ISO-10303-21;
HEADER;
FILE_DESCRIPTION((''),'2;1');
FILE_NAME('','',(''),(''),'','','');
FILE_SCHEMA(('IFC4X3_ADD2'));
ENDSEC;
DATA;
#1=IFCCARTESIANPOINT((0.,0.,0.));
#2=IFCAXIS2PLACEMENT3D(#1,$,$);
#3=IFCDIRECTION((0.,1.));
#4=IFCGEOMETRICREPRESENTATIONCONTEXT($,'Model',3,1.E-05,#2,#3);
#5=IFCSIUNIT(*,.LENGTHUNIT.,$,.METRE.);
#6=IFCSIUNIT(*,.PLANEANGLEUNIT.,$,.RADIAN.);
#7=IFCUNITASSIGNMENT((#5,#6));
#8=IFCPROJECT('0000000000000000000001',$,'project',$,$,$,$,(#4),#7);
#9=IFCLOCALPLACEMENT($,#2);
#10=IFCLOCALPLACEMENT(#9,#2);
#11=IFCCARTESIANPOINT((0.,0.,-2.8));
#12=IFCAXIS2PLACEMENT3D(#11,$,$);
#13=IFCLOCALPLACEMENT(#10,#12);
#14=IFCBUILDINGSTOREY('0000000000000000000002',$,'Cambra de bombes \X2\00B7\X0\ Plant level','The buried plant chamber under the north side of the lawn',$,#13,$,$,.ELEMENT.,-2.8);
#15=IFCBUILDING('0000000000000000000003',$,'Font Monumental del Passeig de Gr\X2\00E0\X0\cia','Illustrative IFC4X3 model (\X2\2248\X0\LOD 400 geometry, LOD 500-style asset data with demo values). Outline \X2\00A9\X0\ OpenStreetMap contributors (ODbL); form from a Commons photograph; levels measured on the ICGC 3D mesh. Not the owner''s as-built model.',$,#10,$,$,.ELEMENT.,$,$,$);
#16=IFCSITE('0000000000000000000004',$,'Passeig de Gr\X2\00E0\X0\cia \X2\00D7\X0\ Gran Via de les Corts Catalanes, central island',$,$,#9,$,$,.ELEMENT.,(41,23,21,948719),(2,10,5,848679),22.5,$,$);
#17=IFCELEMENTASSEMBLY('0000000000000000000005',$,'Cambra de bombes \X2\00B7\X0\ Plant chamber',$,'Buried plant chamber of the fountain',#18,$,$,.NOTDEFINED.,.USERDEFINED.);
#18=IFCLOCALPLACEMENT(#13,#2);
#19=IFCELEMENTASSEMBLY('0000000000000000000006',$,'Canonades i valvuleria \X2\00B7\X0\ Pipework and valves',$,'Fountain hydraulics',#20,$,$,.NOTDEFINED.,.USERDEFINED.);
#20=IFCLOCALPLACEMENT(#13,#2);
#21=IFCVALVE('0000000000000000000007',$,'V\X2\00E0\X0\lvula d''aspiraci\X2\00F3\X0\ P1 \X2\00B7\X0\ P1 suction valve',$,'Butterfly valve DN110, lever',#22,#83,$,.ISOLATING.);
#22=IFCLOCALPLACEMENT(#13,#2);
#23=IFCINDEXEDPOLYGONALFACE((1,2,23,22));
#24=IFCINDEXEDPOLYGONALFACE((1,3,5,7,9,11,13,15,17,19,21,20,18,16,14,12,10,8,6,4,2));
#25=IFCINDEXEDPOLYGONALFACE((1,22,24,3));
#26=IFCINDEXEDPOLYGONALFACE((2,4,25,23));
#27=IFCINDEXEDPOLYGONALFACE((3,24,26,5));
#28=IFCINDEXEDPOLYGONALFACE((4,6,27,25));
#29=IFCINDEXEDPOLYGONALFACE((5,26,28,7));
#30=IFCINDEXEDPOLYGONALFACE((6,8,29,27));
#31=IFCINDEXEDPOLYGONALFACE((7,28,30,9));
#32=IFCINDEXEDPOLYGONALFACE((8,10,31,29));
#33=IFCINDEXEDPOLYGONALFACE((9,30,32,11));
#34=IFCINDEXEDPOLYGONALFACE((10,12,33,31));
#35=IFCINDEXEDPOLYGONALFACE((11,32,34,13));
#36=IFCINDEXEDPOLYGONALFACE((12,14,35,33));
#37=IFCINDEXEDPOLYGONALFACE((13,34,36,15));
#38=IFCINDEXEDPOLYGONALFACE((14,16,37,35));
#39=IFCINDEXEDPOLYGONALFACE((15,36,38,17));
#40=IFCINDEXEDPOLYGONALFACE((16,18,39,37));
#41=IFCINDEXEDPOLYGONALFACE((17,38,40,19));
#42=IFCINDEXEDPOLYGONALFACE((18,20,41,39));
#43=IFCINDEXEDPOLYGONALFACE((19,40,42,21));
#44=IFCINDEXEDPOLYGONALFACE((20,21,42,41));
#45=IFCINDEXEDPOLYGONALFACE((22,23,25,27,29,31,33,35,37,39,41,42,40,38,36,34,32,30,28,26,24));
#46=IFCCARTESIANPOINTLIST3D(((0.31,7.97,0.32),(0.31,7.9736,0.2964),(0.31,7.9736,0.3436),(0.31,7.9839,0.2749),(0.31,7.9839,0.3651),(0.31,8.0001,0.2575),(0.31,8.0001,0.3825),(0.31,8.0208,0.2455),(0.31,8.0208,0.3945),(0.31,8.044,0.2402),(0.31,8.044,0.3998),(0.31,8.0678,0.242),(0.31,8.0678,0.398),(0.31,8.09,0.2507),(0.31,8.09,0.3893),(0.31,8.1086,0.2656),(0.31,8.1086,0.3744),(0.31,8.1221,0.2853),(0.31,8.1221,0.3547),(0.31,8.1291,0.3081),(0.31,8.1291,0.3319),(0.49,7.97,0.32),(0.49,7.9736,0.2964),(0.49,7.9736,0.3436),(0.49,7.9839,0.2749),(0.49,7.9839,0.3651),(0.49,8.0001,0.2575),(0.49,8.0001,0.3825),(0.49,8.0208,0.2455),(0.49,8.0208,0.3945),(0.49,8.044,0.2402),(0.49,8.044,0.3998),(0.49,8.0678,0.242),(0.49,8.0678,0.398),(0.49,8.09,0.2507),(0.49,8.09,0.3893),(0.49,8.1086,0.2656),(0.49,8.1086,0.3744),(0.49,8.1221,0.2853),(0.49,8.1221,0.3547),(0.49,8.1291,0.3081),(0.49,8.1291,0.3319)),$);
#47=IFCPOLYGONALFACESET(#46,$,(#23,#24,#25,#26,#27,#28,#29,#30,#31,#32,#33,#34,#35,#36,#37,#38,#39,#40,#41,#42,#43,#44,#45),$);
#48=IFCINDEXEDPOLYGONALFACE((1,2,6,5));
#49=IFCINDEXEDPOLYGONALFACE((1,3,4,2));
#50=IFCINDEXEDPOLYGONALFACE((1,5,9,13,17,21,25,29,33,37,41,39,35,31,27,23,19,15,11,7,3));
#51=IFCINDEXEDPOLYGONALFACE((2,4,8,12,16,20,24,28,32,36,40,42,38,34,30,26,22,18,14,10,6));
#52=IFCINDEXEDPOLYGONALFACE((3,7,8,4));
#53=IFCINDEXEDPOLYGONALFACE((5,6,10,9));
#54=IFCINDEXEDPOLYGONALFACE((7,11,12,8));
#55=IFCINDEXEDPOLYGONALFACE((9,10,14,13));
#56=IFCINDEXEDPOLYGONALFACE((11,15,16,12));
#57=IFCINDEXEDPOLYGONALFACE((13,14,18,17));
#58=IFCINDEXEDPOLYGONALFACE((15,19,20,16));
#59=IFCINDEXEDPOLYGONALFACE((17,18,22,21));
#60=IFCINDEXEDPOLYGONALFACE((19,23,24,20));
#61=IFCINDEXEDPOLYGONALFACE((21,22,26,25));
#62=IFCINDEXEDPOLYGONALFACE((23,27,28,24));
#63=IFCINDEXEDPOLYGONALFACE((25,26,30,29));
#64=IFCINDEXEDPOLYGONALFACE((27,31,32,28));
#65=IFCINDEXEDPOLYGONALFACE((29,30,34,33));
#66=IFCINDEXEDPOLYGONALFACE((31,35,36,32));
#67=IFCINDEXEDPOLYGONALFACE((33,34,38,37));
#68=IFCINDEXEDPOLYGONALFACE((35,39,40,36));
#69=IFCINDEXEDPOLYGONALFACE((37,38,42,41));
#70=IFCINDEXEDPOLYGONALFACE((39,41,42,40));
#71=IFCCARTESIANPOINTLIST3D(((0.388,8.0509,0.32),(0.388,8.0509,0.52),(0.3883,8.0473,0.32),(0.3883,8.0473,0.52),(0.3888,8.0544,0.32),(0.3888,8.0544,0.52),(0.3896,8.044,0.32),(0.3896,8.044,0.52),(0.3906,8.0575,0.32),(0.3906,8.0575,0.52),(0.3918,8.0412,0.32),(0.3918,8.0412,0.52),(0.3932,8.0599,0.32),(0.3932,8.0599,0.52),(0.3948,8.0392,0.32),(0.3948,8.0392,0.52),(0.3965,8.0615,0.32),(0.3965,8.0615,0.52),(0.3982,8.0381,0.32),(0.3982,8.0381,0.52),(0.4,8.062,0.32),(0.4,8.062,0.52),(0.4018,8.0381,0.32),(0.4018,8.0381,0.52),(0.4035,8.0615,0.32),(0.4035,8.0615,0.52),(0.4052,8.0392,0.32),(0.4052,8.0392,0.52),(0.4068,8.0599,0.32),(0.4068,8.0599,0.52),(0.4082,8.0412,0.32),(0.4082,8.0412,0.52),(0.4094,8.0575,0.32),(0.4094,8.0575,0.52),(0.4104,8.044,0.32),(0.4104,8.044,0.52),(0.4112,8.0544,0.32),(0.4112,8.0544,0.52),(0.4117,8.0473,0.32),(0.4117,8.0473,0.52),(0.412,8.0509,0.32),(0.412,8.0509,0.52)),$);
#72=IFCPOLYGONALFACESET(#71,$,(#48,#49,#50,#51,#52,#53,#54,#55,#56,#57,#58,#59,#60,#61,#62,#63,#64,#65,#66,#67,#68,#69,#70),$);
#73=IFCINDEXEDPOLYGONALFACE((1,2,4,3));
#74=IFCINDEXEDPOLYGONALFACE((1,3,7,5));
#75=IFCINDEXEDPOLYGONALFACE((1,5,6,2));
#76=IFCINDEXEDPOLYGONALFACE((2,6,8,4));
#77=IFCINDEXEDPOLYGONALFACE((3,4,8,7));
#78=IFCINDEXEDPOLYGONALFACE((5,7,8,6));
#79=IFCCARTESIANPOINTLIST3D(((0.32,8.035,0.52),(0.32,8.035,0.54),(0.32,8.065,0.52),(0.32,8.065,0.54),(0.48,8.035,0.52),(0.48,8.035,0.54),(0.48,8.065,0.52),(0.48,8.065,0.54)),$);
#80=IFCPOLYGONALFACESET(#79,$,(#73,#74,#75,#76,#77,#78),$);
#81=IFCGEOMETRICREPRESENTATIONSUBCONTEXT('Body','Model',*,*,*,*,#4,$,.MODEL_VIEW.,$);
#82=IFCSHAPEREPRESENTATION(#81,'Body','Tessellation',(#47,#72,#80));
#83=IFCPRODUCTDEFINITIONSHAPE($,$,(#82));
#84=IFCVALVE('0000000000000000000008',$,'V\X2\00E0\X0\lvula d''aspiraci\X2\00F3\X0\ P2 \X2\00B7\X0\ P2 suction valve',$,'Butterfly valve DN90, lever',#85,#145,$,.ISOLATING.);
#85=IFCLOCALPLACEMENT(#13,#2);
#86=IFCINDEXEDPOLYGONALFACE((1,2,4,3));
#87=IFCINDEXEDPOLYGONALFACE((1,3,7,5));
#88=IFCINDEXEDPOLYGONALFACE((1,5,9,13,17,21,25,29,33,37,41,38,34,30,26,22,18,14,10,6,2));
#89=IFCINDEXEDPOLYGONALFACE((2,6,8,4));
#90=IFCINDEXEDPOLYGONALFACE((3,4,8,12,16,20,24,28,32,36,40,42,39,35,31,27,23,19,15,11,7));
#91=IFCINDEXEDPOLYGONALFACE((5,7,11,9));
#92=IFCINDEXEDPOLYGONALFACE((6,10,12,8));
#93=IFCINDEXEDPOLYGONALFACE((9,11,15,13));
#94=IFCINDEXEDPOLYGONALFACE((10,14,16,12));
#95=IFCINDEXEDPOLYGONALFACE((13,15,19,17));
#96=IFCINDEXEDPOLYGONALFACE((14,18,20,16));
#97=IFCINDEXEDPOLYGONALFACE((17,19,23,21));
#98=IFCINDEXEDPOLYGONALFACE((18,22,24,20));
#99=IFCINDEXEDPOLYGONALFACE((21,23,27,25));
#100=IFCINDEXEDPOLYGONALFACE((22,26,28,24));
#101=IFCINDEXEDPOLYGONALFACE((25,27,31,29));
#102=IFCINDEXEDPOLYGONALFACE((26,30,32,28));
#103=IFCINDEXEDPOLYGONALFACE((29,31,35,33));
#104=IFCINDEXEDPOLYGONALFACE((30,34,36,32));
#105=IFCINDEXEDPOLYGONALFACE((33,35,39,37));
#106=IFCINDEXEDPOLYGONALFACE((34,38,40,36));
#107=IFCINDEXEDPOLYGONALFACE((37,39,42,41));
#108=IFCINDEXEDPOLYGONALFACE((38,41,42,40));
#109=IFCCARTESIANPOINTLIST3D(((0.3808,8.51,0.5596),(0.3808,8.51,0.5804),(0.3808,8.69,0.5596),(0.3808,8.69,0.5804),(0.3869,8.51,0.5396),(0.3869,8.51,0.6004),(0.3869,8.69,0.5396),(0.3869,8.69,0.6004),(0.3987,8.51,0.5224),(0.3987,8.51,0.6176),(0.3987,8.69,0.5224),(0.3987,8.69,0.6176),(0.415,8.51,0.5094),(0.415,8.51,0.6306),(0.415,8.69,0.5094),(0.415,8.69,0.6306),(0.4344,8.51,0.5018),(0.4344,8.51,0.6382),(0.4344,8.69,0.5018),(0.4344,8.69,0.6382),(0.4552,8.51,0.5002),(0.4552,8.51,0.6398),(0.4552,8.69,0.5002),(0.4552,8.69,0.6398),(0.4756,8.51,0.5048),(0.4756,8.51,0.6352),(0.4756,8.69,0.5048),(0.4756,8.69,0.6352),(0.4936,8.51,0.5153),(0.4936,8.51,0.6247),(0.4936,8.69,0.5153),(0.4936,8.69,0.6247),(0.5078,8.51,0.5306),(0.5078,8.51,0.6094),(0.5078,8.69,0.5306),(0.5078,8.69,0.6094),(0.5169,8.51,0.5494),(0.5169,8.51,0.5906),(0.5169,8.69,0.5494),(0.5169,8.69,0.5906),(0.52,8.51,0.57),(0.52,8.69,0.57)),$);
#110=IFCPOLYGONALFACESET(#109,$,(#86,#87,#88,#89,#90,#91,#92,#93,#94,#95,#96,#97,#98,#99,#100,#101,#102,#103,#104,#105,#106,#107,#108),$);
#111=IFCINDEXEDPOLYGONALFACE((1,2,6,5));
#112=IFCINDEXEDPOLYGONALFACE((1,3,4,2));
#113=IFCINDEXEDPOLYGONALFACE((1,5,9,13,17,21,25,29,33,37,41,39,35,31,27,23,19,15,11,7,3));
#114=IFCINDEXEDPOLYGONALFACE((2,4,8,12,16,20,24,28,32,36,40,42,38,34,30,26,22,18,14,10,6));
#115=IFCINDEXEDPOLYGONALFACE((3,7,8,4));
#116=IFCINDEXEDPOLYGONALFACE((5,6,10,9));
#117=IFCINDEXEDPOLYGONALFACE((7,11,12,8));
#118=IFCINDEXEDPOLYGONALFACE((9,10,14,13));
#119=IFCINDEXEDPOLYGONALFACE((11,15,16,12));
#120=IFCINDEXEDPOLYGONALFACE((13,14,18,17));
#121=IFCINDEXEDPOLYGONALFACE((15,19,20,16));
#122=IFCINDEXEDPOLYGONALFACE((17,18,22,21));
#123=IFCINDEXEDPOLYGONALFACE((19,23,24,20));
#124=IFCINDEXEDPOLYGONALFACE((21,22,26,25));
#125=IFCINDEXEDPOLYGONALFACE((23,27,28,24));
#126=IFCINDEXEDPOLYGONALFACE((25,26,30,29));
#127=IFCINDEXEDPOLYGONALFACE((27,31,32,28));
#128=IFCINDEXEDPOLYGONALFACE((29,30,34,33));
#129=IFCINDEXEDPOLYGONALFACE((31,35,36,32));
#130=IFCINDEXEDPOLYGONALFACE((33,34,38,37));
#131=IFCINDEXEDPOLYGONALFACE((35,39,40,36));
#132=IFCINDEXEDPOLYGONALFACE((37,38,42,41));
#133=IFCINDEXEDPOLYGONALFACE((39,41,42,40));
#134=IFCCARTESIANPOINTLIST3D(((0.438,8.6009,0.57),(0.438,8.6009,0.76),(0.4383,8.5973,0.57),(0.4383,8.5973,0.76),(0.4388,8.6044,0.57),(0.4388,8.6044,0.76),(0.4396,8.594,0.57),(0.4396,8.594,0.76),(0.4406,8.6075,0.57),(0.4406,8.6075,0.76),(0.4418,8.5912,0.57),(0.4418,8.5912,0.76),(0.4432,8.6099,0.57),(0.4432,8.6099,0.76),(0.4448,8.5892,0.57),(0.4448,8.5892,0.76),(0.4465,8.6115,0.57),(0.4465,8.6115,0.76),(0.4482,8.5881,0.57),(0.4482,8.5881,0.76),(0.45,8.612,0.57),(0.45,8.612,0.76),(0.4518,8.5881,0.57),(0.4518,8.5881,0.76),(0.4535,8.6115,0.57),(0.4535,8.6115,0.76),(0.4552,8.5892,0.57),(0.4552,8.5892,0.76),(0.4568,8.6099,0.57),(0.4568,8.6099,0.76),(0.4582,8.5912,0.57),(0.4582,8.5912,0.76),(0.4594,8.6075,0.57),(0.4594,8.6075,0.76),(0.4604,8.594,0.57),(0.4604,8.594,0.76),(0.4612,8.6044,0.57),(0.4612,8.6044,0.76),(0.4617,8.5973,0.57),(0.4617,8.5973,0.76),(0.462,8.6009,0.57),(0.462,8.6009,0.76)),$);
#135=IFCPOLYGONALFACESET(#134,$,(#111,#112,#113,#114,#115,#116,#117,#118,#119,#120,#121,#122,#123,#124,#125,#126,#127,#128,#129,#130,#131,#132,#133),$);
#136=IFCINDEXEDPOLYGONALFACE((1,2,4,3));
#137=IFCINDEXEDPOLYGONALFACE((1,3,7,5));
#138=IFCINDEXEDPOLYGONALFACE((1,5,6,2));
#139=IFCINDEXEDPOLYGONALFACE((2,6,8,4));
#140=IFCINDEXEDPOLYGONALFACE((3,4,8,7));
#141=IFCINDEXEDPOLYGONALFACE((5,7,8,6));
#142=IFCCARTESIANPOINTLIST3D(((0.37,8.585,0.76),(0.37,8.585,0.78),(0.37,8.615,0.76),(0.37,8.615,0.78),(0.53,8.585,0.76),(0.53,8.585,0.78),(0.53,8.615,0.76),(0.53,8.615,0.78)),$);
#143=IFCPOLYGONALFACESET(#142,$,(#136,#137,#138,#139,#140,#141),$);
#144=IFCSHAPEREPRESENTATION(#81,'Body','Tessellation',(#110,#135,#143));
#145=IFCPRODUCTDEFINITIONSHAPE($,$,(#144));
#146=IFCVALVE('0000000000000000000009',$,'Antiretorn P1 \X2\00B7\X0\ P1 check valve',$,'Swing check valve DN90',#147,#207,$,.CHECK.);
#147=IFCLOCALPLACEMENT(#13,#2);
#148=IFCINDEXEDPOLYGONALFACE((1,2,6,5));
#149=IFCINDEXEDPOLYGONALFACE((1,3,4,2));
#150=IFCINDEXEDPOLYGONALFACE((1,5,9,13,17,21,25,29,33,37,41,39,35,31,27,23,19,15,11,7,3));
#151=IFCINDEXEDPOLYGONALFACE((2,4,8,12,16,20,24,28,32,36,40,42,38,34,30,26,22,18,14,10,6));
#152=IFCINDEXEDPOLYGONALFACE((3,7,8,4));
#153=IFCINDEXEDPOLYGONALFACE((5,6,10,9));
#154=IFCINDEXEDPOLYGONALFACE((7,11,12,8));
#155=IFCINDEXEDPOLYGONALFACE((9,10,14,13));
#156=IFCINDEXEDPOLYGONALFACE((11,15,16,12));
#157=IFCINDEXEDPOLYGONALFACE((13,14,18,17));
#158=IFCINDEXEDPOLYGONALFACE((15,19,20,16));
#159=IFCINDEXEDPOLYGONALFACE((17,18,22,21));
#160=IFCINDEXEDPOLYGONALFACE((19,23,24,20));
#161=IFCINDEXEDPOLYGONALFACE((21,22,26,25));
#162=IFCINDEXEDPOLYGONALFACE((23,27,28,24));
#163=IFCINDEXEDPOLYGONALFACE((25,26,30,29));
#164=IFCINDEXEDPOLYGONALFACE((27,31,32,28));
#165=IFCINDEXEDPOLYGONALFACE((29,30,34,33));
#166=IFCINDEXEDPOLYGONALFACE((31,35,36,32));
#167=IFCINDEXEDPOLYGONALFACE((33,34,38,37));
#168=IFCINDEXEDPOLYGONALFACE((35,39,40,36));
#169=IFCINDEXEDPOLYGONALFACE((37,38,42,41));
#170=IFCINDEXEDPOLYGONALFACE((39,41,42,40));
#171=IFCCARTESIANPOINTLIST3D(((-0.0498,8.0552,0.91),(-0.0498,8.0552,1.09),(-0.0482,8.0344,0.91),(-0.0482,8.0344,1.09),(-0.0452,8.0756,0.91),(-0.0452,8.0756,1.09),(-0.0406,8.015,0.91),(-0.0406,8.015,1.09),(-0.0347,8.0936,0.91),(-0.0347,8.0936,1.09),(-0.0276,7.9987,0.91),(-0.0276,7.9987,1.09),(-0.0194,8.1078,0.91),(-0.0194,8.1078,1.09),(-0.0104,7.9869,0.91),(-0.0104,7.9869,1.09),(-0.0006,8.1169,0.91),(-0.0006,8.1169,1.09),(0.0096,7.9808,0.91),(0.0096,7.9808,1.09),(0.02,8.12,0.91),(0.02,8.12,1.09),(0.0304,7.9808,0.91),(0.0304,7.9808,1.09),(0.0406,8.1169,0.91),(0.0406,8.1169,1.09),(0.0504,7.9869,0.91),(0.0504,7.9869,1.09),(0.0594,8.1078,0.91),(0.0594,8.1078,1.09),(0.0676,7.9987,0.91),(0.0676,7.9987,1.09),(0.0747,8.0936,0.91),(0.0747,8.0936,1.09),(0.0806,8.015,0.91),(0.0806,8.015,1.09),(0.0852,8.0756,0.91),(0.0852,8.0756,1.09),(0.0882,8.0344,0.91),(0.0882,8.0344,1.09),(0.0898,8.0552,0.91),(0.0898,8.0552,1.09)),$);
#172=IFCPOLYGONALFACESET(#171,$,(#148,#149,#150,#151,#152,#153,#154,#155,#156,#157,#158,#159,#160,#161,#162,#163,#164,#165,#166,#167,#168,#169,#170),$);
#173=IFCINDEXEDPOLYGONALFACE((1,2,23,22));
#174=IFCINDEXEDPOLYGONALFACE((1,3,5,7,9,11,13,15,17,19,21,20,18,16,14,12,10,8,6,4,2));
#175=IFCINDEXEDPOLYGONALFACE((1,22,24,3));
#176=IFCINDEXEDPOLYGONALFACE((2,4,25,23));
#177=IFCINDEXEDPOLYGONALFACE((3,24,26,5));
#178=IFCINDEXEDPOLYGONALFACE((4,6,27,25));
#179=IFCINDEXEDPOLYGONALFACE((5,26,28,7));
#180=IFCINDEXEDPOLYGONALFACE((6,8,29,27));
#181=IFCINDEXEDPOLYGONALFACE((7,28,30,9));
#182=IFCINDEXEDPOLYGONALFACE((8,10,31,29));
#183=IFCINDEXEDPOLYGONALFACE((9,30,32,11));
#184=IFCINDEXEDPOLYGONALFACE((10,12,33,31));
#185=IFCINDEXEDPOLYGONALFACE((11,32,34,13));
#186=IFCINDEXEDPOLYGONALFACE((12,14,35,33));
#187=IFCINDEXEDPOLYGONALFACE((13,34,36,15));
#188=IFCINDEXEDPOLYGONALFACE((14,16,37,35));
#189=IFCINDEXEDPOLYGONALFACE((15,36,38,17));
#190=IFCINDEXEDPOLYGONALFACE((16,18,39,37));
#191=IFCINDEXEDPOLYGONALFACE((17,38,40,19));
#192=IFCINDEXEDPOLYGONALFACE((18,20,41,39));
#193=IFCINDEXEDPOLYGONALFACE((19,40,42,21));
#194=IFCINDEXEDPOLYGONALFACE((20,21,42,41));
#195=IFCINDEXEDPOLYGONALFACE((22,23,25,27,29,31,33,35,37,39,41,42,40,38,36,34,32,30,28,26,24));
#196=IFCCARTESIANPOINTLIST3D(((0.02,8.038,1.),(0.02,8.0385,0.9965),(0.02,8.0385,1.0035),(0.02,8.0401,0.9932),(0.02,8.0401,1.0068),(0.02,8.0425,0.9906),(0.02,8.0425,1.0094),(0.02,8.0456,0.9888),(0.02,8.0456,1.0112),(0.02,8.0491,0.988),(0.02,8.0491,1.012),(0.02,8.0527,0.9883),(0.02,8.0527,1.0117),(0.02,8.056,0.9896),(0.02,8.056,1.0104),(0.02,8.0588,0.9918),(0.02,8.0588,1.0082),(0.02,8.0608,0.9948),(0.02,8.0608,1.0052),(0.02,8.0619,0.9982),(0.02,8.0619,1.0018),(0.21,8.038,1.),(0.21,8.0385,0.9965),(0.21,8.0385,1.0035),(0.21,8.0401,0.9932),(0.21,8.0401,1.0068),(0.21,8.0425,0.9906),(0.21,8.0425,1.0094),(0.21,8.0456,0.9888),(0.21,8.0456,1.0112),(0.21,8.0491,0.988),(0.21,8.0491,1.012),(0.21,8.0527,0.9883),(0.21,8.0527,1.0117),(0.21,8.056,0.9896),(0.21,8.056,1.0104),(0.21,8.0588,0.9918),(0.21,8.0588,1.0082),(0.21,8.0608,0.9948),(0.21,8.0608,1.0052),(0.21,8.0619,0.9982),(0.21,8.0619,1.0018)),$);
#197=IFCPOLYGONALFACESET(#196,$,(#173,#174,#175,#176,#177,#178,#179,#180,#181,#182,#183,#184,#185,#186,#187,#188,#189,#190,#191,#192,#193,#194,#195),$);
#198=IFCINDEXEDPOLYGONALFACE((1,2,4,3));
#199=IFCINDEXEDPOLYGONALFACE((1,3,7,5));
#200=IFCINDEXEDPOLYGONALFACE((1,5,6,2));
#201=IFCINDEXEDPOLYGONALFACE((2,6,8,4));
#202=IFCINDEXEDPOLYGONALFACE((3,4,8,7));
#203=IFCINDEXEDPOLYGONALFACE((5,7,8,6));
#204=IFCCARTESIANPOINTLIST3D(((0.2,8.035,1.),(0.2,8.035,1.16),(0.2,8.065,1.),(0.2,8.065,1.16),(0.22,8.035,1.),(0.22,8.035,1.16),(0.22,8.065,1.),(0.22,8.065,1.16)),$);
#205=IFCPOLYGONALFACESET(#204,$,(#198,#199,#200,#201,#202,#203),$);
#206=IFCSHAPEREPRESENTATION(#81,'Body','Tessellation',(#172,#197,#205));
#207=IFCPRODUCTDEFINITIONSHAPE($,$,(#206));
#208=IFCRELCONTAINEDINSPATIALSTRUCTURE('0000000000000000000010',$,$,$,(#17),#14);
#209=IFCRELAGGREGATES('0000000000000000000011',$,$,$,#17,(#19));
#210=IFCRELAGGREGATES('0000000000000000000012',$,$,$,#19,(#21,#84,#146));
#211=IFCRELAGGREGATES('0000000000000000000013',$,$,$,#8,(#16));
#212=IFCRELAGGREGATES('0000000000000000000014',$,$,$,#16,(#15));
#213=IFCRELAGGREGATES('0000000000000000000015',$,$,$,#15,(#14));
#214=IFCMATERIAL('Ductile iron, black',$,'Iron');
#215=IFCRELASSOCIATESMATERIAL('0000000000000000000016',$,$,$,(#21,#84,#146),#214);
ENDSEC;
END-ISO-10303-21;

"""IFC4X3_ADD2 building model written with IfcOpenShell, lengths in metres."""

from ifc_helpers import new_model, si_unit, direction, frame, origin, origin_2d_with_axis, place, context, subcontext, project, spatial, rectangle, circle, extrude, material, element, aggregate, save


model = new_model("IFC4X3_ADD2")

# Units and contexts
model_context = context("Model", 3, precision=1e-05, world=origin(), true_north=direction((0.0, 1.0)))
body_context = subcontext(model_context, "Body", "Model", "MODEL_VIEW")
ifc_project = project(units=[si_unit("LENGTHUNIT", "METRE"), si_unit("PLANEANGLEUNIT", "RADIAN")], contexts=[model_context])

# Site, building, storey
site_placement = place(None, origin())
site = spatial("IfcSite", under=ifc_project, at=site_placement, Name="Passeig de Gràcia × Gran Via de les Corts Catalanes, central island", CompositionType="ELEMENT", RefLatitude=(41, 23, 21, 948719), RefLongitude=(2, 10, 5, 848679), RefElevation=22.5)
building_placement = place(site_placement, origin())
building = spatial("IfcBuilding", under=site, at=building_placement, Name="Font Monumental del Passeig de Gràcia", Description="Illustrative IFC4X3 model (≈LOD 400 geometry, LOD 500-style asset data with demo values). Outline © OpenStreetMap contributors (ODbL); form from a Commons photograph; levels measured on the ICGC 3D mesh. Not the owner's as-built model.", CompositionType="ELEMENT")
storey_placement = place(building_placement, frame((0.0, 0.0, -2.8)))
storey = spatial("IfcBuildingStorey", under=building, at=storey_placement, Name="Cambra de bombes · Plant level", Description="The buried plant chamber under the north side of the lawn", CompositionType="ELEMENT", Elevation=-2.8)

# Element assemblies, valves
assembly_1_placement = place(building_placement, origin())
assembly_1 = element("IfcElementAssembly", 1, at=assembly_1_placement, inside=storey, Name="Cambra de bombes · Plant chamber", ObjectType="Buried plant chamber of the fountain", AssemblyPlace="NOTDEFINED", PredefinedType="USERDEFINED")
ifc_material_1 = material(Name="Ductile iron, black", Category="Iron")
assembly_2_placement = place(building_placement, origin())
assembly_2 = element("IfcElementAssembly", 2, at=assembly_2_placement, Name="Canonades i valvuleria · Pipework and valves", ObjectType="Fountain hydraulics", AssemblyPlace="NOTDEFINED", PredefinedType="USERDEFINED")
aggregate(assembly_1, [assembly_2])
valve_1_placement = place(building_placement, origin())
valve_1 = element("IfcValve", 3, at=valve_1_placement, material=ifc_material_1, Name="Vàlvula d'aspiració P1 · P1 suction valve", ObjectType="Butterfly valve DN110, lever", PredefinedType="ISOLATING", context=body_context, shape_type="SweptSolid", body=[
    extrude(circle(Radius=0.08, at=origin_2d_with_axis()), frame((0.31, 8.05, -2.48), z_axis=(1.0, 0.0, 0.0), x_axis=(0.0, -1.0, 0.0)), (0.0, 0.0, 1.0), 0.18),
    extrude(circle(Radius=0.012, at=origin_2d_with_axis()), frame((0.4, 8.05, -2.48), z_axis=(0.0, 0.0, 1.0), x_axis=(0.0, 1.0, 0.0)), (0.0, 0.0, 1.0), 0.2),
    extrude(rectangle(XDim=0.16, YDim=0.03, at=origin_2d_with_axis()), frame((0.4, 8.05, -2.28)), (0.0, 0.0, 1.0), 0.02),
])
valve_2_placement = place(building_placement, origin())
valve_2 = element("IfcValve", 4, at=valve_2_placement, material=ifc_material_1, Name="Vàlvula d'aspiració P2 · P2 suction valve", ObjectType="Butterfly valve DN90, lever", PredefinedType="ISOLATING", context=body_context, shape_type="SweptSolid", body=[
    extrude(circle(Radius=0.07, at=origin_2d_with_axis()), frame((0.45, 8.51, -2.23), z_axis=(0.0, 1.0, 0.0), x_axis=(1.0, 0.0, 0.0)), (0.0, 0.0, 1.0), 0.18),
    extrude(circle(Radius=0.012, at=origin_2d_with_axis()), frame((0.45, 8.6, -2.23), z_axis=(0.0, 0.0, 1.0), x_axis=(0.0, 1.0, 0.0)), (0.0, 0.0, 1.0), 0.19),
    extrude(rectangle(XDim=0.16, YDim=0.03, at=origin_2d_with_axis()), frame((0.45, 8.6, -2.04)), (0.0, 0.0, 1.0), 0.02),
])
valve_3_placement = place(building_placement, origin())
valve_3 = element("IfcValve", 5, at=valve_3_placement, material=ifc_material_1, Name="Antiretorn P1 · P1 check valve", ObjectType="Swing check valve DN90", PredefinedType="CHECK", context=body_context, shape_type="SweptSolid", body=[
    extrude(circle(Radius=0.07, at=origin_2d_with_axis()), frame((0.02, 8.05, -1.89), z_axis=(0.0, 0.0, 1.0), x_axis=(0.0, 1.0, 0.0)), (0.0, 0.0, 1.0), 0.18),
    extrude(circle(Radius=0.012, at=origin_2d_with_axis()), frame((0.02, 8.05, -1.8), z_axis=(1.0, 0.0, 0.0), x_axis=(0.0, -1.0, 0.0)), (0.0, 0.0, 1.0), 0.19),
    extrude(rectangle(XDim=0.02, YDim=0.03, at=origin_2d_with_axis()), frame((0.21, 8.05, -1.8)), (0.0, 0.0, 1.0), 0.16),
])
aggregate(assembly_2, [valve_1, valve_2, valve_3])

save(model, "model.ifc")
